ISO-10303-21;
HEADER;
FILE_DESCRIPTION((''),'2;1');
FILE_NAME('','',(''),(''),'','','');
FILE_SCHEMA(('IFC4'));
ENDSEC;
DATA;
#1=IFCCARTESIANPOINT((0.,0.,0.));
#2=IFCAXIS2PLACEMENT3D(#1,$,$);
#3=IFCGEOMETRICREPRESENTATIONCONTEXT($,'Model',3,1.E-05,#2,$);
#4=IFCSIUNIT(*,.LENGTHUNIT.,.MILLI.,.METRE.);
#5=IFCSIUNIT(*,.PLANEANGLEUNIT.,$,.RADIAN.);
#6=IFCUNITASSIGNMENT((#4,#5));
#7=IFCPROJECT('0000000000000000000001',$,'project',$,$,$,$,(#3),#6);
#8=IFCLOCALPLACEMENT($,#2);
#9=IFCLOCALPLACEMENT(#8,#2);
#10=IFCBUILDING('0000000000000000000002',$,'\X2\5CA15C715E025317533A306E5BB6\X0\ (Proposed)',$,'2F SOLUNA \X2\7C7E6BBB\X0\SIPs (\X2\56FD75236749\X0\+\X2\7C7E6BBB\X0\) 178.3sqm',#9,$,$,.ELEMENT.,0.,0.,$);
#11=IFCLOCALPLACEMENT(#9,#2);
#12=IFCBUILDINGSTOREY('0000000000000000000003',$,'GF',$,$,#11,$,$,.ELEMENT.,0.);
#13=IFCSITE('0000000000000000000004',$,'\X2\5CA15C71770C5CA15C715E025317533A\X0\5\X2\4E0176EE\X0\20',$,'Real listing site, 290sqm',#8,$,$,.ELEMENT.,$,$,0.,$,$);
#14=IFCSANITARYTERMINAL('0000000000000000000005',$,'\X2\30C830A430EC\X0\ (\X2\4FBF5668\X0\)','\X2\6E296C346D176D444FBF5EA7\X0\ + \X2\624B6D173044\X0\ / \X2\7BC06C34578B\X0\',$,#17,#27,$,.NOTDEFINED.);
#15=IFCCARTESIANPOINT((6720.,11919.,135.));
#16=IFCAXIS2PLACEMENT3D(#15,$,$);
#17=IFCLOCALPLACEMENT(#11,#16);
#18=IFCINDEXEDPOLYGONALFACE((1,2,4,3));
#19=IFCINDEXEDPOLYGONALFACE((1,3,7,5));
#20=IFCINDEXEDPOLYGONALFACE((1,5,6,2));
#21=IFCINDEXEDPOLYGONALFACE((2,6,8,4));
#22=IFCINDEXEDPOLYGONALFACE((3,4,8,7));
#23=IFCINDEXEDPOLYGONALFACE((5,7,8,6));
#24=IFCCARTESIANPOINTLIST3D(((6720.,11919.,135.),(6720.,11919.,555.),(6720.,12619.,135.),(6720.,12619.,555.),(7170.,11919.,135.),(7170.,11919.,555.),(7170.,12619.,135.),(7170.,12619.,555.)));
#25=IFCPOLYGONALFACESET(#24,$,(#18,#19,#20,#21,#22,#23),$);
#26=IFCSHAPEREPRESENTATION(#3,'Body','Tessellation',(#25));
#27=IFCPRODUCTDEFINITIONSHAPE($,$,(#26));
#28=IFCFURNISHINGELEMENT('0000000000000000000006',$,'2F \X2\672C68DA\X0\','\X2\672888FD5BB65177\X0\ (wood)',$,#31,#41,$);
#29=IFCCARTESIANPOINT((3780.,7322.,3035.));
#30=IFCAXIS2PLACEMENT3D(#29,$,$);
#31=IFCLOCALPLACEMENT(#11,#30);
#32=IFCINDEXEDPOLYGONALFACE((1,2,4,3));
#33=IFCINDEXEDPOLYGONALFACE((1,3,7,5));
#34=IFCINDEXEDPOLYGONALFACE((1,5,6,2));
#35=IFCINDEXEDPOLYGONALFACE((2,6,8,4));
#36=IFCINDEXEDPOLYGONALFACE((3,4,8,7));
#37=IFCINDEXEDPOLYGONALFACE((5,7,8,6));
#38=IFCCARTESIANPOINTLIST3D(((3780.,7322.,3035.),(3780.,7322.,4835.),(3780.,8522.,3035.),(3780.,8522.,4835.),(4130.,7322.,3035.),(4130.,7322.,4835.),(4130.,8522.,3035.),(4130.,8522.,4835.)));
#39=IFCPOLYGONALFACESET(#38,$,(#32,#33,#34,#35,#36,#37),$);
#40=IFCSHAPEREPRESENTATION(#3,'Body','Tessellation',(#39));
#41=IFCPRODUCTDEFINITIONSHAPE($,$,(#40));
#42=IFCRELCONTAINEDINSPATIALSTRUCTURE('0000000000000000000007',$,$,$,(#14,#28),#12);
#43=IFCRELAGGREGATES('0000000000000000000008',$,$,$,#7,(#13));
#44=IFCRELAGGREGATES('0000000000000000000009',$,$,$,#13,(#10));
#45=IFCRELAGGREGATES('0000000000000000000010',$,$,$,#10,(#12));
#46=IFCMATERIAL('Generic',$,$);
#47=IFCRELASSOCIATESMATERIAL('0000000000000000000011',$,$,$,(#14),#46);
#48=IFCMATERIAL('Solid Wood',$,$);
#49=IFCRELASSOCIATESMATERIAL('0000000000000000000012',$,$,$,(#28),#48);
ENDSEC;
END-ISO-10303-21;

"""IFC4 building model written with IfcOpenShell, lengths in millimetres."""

from ifc_helpers import new_model, si_unit, frame, frame_2d, origin, place, context, project, spatial, rectangle, extrude, material, element, save


model = new_model("IFC4")

# Units and contexts
model_context = context("Model", 3, precision=1e-05, world=origin())
ifc_project = project(units=[si_unit("LENGTHUNIT", "METRE", prefix="MILLI"), si_unit("PLANEANGLEUNIT", "RADIAN")], contexts=[model_context])

# Site, building, storey
site_placement = place(None, origin())
site = spatial("IfcSite", under=ifc_project, at=site_placement, Name="岡山県岡山市北区5丁目20", ObjectType="Real listing site, 290sqm", CompositionType="ELEMENT", RefElevation=0.0)
building_placement = place(site_placement, origin())
building = spatial("IfcBuilding", under=site, at=building_placement, Name="岡山市北区の家 (Proposed)", ObjectType="2F SOLUNA 籾殻SIPs (国産杉+籾殻) 178.3sqm", CompositionType="ELEMENT", ElevationOfRefHeight=0.0, ElevationOfTerrain=0.0)
storey_placement = place(building_placement, origin())
storey = spatial("IfcBuildingStorey", under=building, at=storey_placement, Name="GF", CompositionType="ELEMENT", Elevation=0.0)

# Shared definitions
ifc_material_1 = material(Name="Solid Wood")
ifc_material_2 = material(Name="Generic")

# Sanitary terminal
sanitary_terminal_1_placement = place(storey_placement, frame((6720.0, 11919.0, 135.0)))
element("IfcSanitaryTerminal", 1, at=sanitary_terminal_1_placement, inside=storey, material=ifc_material_2, Name="トイレ (便器)", Description="温水洗浄便座 + 手洗い / 節水型", PredefinedType="NOTDEFINED", context=model_context, shape_type="SweptSolid", body=[
    extrude(rectangle(XDim=450.0, YDim=700.0, at=frame_2d((225.0, 350.0))), frame((6720.0, 11919.0, 135.0)), (0.0, 0.0, 1.0), 420.0),
])

# Furnishing element
furnishing_placement = place(storey_placement, frame((3780.0, 7322.0, 3035.0)))
element("IfcFurnishingElement", 2, at=furnishing_placement, inside=storey, material=ifc_material_1, Name="2F 本棚", Description="木製家具 (wood)", context=model_context, shape_type="SweptSolid", body=[
    extrude(rectangle(XDim=350.0, YDim=1200.0, at=frame_2d((175.0, 600.0))), frame((3780.0, 7322.0, 3035.0)), (0.0, 0.0, 1.0), 1800.0),
])

save(model, "model.ifc")
